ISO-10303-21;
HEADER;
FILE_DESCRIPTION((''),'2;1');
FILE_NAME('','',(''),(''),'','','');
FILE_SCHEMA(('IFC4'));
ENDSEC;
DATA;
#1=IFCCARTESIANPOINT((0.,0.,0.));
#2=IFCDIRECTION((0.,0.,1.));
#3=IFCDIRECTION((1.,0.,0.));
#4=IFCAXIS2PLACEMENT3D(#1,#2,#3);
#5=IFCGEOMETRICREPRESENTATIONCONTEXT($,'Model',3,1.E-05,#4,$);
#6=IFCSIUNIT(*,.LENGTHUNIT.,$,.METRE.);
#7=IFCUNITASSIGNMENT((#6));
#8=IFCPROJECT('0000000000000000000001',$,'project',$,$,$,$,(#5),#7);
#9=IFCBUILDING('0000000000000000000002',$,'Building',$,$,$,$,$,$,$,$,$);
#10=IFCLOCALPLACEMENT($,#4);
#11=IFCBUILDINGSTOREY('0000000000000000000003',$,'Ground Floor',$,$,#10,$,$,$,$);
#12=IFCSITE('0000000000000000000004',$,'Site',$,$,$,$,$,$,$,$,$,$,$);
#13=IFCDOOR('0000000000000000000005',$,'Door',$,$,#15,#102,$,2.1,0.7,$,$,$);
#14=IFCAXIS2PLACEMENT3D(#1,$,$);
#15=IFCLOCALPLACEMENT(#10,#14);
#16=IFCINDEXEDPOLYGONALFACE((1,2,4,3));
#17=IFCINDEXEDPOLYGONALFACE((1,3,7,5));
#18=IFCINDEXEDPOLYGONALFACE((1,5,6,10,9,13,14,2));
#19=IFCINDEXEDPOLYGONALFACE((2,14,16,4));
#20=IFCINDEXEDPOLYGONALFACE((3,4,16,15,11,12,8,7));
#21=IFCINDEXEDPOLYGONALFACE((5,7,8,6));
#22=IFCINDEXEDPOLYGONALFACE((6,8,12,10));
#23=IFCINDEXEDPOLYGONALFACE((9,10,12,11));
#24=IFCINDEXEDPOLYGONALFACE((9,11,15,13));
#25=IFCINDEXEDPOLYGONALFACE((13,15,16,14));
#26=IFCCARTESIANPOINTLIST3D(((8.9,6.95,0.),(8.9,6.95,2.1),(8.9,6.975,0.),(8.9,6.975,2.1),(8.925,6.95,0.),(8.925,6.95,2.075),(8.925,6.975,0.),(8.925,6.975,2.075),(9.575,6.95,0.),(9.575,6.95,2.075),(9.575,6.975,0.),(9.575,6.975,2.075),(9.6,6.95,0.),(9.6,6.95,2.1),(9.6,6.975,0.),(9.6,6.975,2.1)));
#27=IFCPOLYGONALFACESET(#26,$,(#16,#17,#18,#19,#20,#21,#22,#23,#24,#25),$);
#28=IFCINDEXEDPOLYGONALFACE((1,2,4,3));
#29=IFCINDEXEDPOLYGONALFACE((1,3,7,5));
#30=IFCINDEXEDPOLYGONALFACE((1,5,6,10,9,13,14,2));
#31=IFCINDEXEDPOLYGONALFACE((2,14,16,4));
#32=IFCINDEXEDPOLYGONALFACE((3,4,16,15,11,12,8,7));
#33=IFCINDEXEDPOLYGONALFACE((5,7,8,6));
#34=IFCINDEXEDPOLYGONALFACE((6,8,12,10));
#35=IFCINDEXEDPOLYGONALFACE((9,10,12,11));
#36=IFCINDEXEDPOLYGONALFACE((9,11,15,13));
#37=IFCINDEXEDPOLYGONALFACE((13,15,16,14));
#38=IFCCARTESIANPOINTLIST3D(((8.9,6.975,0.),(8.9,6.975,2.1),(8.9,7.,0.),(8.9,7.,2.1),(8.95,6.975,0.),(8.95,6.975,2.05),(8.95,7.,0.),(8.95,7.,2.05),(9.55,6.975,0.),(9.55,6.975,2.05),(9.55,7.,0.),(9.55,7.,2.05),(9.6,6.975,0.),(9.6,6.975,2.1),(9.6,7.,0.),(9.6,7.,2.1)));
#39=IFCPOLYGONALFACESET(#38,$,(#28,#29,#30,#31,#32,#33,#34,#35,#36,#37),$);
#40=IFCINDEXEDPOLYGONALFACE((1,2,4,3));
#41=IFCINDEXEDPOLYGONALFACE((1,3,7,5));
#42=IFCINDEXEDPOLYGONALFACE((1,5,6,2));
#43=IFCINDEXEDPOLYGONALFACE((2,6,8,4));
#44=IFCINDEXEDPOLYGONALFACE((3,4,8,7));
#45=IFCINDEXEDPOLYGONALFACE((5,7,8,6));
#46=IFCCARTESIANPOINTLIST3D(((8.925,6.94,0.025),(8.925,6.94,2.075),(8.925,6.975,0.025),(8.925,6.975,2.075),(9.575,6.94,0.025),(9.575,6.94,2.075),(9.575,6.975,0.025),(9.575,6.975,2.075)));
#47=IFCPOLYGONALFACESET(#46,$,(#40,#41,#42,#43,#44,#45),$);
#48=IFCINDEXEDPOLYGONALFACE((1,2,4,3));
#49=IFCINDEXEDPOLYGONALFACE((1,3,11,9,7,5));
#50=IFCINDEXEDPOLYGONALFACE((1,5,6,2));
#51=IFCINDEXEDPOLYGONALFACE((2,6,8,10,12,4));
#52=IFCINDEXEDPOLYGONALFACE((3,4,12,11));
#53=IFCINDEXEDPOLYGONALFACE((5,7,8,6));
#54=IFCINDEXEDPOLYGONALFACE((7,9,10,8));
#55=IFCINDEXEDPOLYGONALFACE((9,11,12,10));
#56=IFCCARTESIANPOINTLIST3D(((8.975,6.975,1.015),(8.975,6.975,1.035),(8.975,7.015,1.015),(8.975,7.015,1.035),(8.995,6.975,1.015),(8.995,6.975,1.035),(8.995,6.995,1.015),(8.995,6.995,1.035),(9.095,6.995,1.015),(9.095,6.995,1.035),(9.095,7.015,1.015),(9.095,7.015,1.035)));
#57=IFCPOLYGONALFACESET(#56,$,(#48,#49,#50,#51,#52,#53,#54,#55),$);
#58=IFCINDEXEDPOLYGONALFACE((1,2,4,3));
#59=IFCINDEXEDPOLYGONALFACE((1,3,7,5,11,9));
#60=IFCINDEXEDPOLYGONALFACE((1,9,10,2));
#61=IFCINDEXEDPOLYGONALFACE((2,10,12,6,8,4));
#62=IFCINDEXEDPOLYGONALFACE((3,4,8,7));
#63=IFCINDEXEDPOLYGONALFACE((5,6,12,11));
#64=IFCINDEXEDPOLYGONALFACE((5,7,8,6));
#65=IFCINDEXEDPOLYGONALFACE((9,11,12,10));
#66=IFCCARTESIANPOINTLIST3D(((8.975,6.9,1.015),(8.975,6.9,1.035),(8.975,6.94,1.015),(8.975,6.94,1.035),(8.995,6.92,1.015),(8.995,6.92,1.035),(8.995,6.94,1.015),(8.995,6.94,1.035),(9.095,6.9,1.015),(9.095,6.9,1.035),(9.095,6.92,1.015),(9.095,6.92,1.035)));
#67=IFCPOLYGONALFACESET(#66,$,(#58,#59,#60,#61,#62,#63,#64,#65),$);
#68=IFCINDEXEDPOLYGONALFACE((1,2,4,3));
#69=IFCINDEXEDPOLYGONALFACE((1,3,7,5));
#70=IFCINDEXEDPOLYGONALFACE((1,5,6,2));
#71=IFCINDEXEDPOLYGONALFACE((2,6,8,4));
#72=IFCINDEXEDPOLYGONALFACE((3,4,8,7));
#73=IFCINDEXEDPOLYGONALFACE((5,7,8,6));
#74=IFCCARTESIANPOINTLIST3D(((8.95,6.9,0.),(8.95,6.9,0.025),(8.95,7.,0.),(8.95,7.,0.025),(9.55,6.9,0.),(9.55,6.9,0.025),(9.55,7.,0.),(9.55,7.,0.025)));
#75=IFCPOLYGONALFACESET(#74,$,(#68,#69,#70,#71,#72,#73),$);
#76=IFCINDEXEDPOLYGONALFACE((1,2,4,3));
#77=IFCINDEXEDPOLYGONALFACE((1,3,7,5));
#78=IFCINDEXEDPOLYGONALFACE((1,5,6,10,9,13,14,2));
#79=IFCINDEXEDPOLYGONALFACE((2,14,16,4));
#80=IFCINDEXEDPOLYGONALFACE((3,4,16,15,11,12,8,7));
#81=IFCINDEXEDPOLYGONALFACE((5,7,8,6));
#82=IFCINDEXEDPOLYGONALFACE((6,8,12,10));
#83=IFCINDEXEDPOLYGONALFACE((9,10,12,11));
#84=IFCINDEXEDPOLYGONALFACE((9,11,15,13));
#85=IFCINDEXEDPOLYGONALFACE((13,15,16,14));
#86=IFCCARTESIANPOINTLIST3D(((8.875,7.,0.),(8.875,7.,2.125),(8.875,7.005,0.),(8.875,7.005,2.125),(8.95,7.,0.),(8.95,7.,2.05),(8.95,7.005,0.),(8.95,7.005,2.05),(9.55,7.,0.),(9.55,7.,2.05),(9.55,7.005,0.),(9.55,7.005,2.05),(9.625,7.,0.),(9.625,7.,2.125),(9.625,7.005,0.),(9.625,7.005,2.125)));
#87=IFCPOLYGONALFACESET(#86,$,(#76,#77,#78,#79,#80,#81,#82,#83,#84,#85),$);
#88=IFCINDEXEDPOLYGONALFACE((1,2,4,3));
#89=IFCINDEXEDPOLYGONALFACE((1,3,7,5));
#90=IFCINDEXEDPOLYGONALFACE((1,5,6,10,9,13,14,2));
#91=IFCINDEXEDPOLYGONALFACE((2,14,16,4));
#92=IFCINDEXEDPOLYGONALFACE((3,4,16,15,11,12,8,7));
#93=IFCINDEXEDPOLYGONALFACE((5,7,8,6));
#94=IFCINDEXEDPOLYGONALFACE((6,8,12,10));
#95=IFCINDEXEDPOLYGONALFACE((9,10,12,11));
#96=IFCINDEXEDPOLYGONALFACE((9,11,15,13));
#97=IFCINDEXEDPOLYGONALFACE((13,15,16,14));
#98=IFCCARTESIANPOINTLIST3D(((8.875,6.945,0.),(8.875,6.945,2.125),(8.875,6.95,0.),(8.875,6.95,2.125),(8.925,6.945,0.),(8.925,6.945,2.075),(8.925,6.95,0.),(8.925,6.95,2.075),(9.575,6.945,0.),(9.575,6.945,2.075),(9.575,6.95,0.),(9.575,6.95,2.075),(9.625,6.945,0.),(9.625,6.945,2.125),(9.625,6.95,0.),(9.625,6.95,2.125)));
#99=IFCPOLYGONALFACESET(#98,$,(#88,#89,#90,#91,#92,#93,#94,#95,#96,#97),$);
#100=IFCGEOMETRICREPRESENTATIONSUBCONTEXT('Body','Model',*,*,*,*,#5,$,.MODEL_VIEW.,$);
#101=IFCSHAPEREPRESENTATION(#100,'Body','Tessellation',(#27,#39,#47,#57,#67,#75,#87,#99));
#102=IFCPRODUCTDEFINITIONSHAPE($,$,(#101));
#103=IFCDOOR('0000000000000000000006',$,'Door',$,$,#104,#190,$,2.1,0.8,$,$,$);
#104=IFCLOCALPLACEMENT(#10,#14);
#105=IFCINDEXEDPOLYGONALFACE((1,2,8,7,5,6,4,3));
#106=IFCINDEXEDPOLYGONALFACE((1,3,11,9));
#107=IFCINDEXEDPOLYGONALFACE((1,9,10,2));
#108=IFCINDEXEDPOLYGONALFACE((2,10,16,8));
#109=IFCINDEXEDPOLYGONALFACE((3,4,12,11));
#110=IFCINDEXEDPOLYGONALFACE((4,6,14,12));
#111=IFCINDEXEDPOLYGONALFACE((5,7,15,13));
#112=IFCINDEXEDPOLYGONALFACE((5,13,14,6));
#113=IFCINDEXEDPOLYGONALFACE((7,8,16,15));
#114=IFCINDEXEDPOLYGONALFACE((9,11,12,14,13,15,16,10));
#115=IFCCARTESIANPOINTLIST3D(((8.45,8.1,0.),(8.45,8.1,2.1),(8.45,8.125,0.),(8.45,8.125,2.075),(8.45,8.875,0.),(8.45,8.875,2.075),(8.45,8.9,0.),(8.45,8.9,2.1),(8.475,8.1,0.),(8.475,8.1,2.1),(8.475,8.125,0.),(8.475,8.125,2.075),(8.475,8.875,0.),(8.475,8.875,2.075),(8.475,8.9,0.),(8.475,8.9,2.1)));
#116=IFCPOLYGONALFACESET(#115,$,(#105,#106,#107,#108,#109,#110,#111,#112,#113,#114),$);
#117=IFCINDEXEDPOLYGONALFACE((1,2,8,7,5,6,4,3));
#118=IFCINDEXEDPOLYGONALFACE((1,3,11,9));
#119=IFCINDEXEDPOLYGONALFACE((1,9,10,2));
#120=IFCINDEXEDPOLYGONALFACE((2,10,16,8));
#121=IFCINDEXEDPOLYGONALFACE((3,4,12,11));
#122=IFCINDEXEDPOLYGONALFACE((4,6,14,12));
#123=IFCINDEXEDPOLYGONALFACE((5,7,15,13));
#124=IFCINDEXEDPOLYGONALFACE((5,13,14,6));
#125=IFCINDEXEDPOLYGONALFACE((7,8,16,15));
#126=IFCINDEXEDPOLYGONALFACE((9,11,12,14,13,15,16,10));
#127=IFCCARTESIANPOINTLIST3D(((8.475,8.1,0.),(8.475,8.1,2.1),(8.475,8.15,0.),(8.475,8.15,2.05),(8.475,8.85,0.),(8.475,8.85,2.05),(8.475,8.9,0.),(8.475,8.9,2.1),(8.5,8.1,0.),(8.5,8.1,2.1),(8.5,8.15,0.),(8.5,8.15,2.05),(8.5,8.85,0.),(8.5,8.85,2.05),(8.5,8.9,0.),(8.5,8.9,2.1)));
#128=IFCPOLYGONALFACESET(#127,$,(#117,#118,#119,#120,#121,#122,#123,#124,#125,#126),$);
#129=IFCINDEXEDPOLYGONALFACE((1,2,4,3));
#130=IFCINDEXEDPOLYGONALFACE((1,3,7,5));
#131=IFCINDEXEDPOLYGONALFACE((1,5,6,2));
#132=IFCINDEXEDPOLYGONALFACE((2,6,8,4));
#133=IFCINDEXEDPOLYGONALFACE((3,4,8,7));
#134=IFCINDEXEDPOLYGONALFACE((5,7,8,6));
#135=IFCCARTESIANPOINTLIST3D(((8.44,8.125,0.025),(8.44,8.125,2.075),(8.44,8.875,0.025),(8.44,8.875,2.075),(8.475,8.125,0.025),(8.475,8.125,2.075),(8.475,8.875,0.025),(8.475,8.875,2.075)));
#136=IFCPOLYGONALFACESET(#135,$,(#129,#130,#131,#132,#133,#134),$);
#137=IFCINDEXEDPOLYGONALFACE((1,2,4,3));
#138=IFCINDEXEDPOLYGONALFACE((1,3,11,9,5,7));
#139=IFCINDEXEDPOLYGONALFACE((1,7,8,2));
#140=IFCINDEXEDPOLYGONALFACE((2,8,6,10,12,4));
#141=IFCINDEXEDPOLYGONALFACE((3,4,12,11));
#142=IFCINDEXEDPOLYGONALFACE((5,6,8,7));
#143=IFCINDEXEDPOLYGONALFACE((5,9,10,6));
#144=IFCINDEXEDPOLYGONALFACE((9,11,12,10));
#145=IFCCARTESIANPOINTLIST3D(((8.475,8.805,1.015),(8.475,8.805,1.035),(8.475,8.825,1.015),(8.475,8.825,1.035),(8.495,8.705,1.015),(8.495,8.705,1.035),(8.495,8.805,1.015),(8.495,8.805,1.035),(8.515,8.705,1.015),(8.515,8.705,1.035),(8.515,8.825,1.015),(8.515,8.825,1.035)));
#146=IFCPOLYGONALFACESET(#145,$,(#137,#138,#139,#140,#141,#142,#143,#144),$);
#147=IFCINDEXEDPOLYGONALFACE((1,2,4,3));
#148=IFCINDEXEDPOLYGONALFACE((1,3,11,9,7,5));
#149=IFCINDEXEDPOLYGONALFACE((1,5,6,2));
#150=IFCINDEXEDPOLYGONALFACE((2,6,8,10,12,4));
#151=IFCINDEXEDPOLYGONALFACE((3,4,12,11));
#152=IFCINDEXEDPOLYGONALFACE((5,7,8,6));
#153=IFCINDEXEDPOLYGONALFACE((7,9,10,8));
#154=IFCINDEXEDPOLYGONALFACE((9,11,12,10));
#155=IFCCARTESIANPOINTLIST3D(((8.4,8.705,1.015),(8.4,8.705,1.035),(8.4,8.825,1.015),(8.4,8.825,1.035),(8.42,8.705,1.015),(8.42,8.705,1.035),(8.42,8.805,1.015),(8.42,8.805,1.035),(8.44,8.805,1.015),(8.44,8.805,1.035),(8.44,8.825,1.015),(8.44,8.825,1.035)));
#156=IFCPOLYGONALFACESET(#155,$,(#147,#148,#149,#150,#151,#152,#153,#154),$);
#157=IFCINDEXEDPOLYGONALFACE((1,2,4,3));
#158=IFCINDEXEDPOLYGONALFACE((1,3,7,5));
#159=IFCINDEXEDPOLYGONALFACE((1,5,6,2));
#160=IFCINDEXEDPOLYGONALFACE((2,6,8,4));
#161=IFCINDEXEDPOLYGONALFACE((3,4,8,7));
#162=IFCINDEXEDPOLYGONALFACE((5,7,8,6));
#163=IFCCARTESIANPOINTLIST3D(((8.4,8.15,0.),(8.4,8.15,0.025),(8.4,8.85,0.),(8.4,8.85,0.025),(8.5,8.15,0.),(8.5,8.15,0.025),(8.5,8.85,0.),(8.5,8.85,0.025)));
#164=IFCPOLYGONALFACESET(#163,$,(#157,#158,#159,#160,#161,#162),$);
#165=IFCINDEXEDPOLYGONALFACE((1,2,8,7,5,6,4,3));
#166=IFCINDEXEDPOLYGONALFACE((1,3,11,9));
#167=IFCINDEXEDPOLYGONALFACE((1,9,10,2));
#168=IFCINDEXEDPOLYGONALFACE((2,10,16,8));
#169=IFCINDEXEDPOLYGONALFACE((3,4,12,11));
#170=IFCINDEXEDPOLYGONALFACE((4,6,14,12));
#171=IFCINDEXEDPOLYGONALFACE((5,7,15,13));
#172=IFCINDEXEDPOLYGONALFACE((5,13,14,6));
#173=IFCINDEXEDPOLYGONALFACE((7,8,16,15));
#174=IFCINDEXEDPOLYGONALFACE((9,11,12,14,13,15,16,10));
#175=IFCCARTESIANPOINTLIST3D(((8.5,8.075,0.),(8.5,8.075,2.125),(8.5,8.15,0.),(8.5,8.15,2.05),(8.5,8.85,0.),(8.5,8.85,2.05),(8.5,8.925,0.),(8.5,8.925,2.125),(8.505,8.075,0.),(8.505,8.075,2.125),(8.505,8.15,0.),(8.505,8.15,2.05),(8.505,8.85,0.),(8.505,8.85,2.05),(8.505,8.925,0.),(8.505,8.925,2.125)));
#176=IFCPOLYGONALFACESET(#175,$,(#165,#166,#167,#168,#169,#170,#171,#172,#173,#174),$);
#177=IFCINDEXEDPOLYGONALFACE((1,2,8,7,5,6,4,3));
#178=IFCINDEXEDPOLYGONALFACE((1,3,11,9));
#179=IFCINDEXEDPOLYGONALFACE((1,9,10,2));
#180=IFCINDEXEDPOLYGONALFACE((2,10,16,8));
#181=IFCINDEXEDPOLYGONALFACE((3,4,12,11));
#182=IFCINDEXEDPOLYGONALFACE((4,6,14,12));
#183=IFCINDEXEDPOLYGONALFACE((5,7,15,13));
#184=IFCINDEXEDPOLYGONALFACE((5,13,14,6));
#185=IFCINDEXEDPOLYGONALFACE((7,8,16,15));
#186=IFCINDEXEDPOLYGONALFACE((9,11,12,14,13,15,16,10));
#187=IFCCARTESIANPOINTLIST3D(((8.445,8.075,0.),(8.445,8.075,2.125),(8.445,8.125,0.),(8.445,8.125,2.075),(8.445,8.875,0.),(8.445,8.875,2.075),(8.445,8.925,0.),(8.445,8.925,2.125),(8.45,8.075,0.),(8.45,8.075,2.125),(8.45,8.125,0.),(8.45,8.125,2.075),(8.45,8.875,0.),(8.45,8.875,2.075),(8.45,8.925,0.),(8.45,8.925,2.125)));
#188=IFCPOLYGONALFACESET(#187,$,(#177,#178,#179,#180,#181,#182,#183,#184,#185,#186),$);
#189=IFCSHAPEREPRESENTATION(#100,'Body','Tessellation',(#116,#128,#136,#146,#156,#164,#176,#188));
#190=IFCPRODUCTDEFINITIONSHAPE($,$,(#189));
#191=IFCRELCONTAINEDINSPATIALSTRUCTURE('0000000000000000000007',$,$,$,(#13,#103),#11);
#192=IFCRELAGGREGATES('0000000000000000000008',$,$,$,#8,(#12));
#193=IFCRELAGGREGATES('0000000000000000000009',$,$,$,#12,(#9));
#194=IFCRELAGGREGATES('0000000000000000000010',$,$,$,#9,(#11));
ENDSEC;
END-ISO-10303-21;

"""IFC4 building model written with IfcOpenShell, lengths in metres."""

from ifc_helpers import new_model, si_unit, frame, origin_with_axes, place, context, subcontext, project, spatial, line, indexed_curve, outline, extrude, element, save


model = new_model("IFC4")

# Units and contexts
model_context = context("Model", 3, precision=1e-05, world=origin_with_axes())
body_context = subcontext(model_context, "Body", "Model", "MODEL_VIEW")
ifc_project = project(units=[si_unit("LENGTHUNIT", "METRE")], contexts=[model_context])

# Site, building, storey
site = spatial("IfcSite", under=ifc_project, Name="Site")
building = spatial("IfcBuilding", under=site, Name="Building")
storey_placement = place(None, origin_with_axes())
storey = spatial("IfcBuildingStorey", under=building, at=storey_placement, Name="Ground Floor")

# Doors
door_1_placement = place(storey_placement, frame((9.6, 7.0, 0.0), z_axis=(0.0, 0.0, 1.0), x_axis=(-1.0, 0.0, 0.0)))
element("IfcDoor", 1, at=door_1_placement, inside=storey, Name="Door", OverallHeight=2.1, OverallWidth=0.7, context=body_context, shape_type="SweptSolid", body=[
    extrude(outline(indexed_curve([(0.0, 0.0), (0.0, 2.1), (0.7, 2.1), (0.7, 0.0), (0.675, 0.0), (0.675, 2.075), (0.025, 2.075), (0.025, 0.0)], segments=[line(1, 2, 3, 4, 5, 6, 7, 8, 1)])), frame((0.0, 0.025, 0.0), z_axis=(0.0, -1.0, 0.0), x_axis=(1.0, 0.0, 0.0)), (0.0, 0.0, -1.0), 0.025),
    extrude(outline(indexed_curve([(0.0, 0.0), (0.0, 2.1), (0.7, 2.1), (0.7, 0.0), (0.65, 0.0), (0.65, 2.05), (0.05, 2.05), (0.05, 0.0)], segments=[line(1, 2, 3, 4, 5, 6, 7, 8, 1)])), frame((0.0, 0.0, 0.0), z_axis=(0.0, -1.0, 0.0), x_axis=(1.0, 0.0, 0.0)), (0.0, 0.0, -1.0), 0.025),
    extrude(outline(indexed_curve([(0.0, 0.0), (0.65, 0.0), (0.65, 0.035), (0.0, 0.035)], segments=[line(1, 2, 3, 4, 1)])), frame((0.025, 0.025, 0.025), z_axis=(0.0, 0.0, 1.0), x_axis=(1.0, 0.0, 0.0)), (0.0, 0.0, 1.0), 2.05),
    extrude(outline(indexed_curve([(0.0, 0.0), (0.0, -0.04), (-0.12, -0.04), (-0.12, -0.02), (-0.02, -0.02), (-0.02, 0.0)], segments=[line(1, 2, 3, 4, 5, 6, 1)])), frame((0.625, 0.025, 1.015), z_axis=(0.0, 0.0, 1.0), x_axis=(1.0, 0.0, 0.0)), (0.0, 0.0, 1.0), 0.02),
    extrude(outline(indexed_curve([(0.0, 0.0), (0.0, 0.04), (-0.12, 0.04), (-0.12, 0.02), (-0.02, 0.02), (-0.02, 0.0)], segments=[line(1, 2, 3, 4, 5, 6, 1)])), frame((0.625, 0.06, 1.015), z_axis=(0.0, 0.0, 1.0), x_axis=(1.0, 0.0, 0.0)), (0.0, 0.0, 1.0), 0.02),
    extrude(outline(indexed_curve([(0.0, 0.0), (0.6, 0.0), (0.6, 0.1), (0.0, 0.1)], segments=[line(1, 2, 3, 4, 1)])), frame((0.05, 0.0, 0.0), z_axis=(0.0, 0.0, 1.0), x_axis=(1.0, 0.0, 0.0)), (0.0, 0.0, 1.0), 0.025),
    extrude(outline(indexed_curve([(0.0, 0.0), (0.0, 2.125), (0.75, 2.125), (0.75, 0.0), (0.675, 0.0), (0.675, 2.05), (0.075, 2.05), (0.075, 0.0)], segments=[line(1, 2, 3, 4, 5, 6, 7, 8, 1)])), frame((-0.025, -0.005, 0.0), z_axis=(0.0, -1.0, 0.0), x_axis=(1.0, 0.0, 0.0)), (0.0, 0.0, -1.0), 0.005),
    extrude(outline(indexed_curve([(0.0, 0.0), (0.0, 2.125), (0.75, 2.125), (0.75, 0.0), (0.7, 0.0), (0.7, 2.075), (0.05, 2.075), (0.05, 0.0)], segments=[line(1, 2, 3, 4, 5, 6, 7, 8, 1)])), frame((-0.025, 0.05, 0.0), z_axis=(0.0, -1.0, 0.0), x_axis=(1.0, 0.0, 0.0)), (0.0, 0.0, -1.0), 0.005),
])
door_2_placement = place(storey_placement, frame((8.5, 8.1, 0.0), z_axis=(0.0, 0.0, 1.0), x_axis=(0.0, 1.0, 0.0)))
element("IfcDoor", 2, at=door_2_placement, inside=storey, Name="Door", OverallHeight=2.1, OverallWidth=0.8, context=body_context, shape_type="SweptSolid", body=[
    extrude(outline(indexed_curve([(0.0, 0.0), (0.0, 2.1), (0.8, 2.1), (0.8, 0.0), (0.775, 0.0), (0.775, 2.075), (0.025, 2.075), (0.025, 0.0)], segments=[line(1, 2, 3, 4, 5, 6, 7, 8, 1)])), frame((0.0, 0.025, 0.0), z_axis=(0.0, -1.0, 0.0), x_axis=(1.0, 0.0, 0.0)), (0.0, 0.0, -1.0), 0.025),
    extrude(outline(indexed_curve([(0.0, 0.0), (0.0, 2.1), (0.8, 2.1), (0.8, 0.0), (0.75, 0.0), (0.75, 2.05), (0.05, 2.05), (0.05, 0.0)], segments=[line(1, 2, 3, 4, 5, 6, 7, 8, 1)])), frame((0.0, 0.0, 0.0), z_axis=(0.0, -1.0, 0.0), x_axis=(1.0, 0.0, 0.0)), (0.0, 0.0, -1.0), 0.025),
    extrude(outline(indexed_curve([(0.0, 0.0), (0.75, 0.0), (0.75, 0.035), (0.0, 0.035)], segments=[line(1, 2, 3, 4, 1)])), frame((0.025, 0.025, 0.025), z_axis=(0.0, 0.0, 1.0), x_axis=(1.0, 0.0, 0.0)), (0.0, 0.0, 1.0), 2.05),
    extrude(outline(indexed_curve([(0.0, 0.0), (0.0, -0.04), (-0.12, -0.04), (-0.12, -0.02), (-0.02, -0.02), (-0.02, 0.0)], segments=[line(1, 2, 3, 4, 5, 6, 1)])), frame((0.725, 0.025, 1.015), z_axis=(0.0, 0.0, 1.0), x_axis=(1.0, 0.0, 0.0)), (0.0, 0.0, 1.0), 0.02),
    extrude(outline(indexed_curve([(0.0, 0.0), (0.0, 0.04), (-0.12, 0.04), (-0.12, 0.02), (-0.02, 0.02), (-0.02, 0.0)], segments=[line(1, 2, 3, 4, 5, 6, 1)])), frame((0.725, 0.06, 1.015), z_axis=(0.0, 0.0, 1.0), x_axis=(1.0, 0.0, 0.0)), (0.0, 0.0, 1.0), 0.02),
    extrude(outline(indexed_curve([(0.0, 0.0), (0.7, 0.0), (0.7, 0.1), (0.0, 0.1)], segments=[line(1, 2, 3, 4, 1)])), frame((0.05, 0.0, 0.0), z_axis=(0.0, 0.0, 1.0), x_axis=(1.0, 0.0, 0.0)), (0.0, 0.0, 1.0), 0.025),
    extrude(outline(indexed_curve([(0.0, 0.0), (0.0, 2.125), (0.85, 2.125), (0.85, 0.0), (0.775, 0.0), (0.775, 2.05), (0.075, 2.05), (0.075, 0.0)], segments=[line(1, 2, 3, 4, 5, 6, 7, 8, 1)])), frame((-0.025, -0.005, 0.0), z_axis=(0.0, -1.0, 0.0), x_axis=(1.0, 0.0, 0.0)), (0.0, 0.0, -1.0), 0.005),
    extrude(outline(indexed_curve([(0.0, 0.0), (0.0, 2.125), (0.85, 2.125), (0.85, 0.0), (0.8, 0.0), (0.8, 2.075), (0.05, 2.075), (0.05, 0.0)], segments=[line(1, 2, 3, 4, 5, 6, 7, 8, 1)])), frame((-0.025, 0.05, 0.0), z_axis=(0.0, -1.0, 0.0), x_axis=(1.0, 0.0, 0.0)), (0.0, 0.0, -1.0), 0.005),
])

save(model, "model.ifc")
